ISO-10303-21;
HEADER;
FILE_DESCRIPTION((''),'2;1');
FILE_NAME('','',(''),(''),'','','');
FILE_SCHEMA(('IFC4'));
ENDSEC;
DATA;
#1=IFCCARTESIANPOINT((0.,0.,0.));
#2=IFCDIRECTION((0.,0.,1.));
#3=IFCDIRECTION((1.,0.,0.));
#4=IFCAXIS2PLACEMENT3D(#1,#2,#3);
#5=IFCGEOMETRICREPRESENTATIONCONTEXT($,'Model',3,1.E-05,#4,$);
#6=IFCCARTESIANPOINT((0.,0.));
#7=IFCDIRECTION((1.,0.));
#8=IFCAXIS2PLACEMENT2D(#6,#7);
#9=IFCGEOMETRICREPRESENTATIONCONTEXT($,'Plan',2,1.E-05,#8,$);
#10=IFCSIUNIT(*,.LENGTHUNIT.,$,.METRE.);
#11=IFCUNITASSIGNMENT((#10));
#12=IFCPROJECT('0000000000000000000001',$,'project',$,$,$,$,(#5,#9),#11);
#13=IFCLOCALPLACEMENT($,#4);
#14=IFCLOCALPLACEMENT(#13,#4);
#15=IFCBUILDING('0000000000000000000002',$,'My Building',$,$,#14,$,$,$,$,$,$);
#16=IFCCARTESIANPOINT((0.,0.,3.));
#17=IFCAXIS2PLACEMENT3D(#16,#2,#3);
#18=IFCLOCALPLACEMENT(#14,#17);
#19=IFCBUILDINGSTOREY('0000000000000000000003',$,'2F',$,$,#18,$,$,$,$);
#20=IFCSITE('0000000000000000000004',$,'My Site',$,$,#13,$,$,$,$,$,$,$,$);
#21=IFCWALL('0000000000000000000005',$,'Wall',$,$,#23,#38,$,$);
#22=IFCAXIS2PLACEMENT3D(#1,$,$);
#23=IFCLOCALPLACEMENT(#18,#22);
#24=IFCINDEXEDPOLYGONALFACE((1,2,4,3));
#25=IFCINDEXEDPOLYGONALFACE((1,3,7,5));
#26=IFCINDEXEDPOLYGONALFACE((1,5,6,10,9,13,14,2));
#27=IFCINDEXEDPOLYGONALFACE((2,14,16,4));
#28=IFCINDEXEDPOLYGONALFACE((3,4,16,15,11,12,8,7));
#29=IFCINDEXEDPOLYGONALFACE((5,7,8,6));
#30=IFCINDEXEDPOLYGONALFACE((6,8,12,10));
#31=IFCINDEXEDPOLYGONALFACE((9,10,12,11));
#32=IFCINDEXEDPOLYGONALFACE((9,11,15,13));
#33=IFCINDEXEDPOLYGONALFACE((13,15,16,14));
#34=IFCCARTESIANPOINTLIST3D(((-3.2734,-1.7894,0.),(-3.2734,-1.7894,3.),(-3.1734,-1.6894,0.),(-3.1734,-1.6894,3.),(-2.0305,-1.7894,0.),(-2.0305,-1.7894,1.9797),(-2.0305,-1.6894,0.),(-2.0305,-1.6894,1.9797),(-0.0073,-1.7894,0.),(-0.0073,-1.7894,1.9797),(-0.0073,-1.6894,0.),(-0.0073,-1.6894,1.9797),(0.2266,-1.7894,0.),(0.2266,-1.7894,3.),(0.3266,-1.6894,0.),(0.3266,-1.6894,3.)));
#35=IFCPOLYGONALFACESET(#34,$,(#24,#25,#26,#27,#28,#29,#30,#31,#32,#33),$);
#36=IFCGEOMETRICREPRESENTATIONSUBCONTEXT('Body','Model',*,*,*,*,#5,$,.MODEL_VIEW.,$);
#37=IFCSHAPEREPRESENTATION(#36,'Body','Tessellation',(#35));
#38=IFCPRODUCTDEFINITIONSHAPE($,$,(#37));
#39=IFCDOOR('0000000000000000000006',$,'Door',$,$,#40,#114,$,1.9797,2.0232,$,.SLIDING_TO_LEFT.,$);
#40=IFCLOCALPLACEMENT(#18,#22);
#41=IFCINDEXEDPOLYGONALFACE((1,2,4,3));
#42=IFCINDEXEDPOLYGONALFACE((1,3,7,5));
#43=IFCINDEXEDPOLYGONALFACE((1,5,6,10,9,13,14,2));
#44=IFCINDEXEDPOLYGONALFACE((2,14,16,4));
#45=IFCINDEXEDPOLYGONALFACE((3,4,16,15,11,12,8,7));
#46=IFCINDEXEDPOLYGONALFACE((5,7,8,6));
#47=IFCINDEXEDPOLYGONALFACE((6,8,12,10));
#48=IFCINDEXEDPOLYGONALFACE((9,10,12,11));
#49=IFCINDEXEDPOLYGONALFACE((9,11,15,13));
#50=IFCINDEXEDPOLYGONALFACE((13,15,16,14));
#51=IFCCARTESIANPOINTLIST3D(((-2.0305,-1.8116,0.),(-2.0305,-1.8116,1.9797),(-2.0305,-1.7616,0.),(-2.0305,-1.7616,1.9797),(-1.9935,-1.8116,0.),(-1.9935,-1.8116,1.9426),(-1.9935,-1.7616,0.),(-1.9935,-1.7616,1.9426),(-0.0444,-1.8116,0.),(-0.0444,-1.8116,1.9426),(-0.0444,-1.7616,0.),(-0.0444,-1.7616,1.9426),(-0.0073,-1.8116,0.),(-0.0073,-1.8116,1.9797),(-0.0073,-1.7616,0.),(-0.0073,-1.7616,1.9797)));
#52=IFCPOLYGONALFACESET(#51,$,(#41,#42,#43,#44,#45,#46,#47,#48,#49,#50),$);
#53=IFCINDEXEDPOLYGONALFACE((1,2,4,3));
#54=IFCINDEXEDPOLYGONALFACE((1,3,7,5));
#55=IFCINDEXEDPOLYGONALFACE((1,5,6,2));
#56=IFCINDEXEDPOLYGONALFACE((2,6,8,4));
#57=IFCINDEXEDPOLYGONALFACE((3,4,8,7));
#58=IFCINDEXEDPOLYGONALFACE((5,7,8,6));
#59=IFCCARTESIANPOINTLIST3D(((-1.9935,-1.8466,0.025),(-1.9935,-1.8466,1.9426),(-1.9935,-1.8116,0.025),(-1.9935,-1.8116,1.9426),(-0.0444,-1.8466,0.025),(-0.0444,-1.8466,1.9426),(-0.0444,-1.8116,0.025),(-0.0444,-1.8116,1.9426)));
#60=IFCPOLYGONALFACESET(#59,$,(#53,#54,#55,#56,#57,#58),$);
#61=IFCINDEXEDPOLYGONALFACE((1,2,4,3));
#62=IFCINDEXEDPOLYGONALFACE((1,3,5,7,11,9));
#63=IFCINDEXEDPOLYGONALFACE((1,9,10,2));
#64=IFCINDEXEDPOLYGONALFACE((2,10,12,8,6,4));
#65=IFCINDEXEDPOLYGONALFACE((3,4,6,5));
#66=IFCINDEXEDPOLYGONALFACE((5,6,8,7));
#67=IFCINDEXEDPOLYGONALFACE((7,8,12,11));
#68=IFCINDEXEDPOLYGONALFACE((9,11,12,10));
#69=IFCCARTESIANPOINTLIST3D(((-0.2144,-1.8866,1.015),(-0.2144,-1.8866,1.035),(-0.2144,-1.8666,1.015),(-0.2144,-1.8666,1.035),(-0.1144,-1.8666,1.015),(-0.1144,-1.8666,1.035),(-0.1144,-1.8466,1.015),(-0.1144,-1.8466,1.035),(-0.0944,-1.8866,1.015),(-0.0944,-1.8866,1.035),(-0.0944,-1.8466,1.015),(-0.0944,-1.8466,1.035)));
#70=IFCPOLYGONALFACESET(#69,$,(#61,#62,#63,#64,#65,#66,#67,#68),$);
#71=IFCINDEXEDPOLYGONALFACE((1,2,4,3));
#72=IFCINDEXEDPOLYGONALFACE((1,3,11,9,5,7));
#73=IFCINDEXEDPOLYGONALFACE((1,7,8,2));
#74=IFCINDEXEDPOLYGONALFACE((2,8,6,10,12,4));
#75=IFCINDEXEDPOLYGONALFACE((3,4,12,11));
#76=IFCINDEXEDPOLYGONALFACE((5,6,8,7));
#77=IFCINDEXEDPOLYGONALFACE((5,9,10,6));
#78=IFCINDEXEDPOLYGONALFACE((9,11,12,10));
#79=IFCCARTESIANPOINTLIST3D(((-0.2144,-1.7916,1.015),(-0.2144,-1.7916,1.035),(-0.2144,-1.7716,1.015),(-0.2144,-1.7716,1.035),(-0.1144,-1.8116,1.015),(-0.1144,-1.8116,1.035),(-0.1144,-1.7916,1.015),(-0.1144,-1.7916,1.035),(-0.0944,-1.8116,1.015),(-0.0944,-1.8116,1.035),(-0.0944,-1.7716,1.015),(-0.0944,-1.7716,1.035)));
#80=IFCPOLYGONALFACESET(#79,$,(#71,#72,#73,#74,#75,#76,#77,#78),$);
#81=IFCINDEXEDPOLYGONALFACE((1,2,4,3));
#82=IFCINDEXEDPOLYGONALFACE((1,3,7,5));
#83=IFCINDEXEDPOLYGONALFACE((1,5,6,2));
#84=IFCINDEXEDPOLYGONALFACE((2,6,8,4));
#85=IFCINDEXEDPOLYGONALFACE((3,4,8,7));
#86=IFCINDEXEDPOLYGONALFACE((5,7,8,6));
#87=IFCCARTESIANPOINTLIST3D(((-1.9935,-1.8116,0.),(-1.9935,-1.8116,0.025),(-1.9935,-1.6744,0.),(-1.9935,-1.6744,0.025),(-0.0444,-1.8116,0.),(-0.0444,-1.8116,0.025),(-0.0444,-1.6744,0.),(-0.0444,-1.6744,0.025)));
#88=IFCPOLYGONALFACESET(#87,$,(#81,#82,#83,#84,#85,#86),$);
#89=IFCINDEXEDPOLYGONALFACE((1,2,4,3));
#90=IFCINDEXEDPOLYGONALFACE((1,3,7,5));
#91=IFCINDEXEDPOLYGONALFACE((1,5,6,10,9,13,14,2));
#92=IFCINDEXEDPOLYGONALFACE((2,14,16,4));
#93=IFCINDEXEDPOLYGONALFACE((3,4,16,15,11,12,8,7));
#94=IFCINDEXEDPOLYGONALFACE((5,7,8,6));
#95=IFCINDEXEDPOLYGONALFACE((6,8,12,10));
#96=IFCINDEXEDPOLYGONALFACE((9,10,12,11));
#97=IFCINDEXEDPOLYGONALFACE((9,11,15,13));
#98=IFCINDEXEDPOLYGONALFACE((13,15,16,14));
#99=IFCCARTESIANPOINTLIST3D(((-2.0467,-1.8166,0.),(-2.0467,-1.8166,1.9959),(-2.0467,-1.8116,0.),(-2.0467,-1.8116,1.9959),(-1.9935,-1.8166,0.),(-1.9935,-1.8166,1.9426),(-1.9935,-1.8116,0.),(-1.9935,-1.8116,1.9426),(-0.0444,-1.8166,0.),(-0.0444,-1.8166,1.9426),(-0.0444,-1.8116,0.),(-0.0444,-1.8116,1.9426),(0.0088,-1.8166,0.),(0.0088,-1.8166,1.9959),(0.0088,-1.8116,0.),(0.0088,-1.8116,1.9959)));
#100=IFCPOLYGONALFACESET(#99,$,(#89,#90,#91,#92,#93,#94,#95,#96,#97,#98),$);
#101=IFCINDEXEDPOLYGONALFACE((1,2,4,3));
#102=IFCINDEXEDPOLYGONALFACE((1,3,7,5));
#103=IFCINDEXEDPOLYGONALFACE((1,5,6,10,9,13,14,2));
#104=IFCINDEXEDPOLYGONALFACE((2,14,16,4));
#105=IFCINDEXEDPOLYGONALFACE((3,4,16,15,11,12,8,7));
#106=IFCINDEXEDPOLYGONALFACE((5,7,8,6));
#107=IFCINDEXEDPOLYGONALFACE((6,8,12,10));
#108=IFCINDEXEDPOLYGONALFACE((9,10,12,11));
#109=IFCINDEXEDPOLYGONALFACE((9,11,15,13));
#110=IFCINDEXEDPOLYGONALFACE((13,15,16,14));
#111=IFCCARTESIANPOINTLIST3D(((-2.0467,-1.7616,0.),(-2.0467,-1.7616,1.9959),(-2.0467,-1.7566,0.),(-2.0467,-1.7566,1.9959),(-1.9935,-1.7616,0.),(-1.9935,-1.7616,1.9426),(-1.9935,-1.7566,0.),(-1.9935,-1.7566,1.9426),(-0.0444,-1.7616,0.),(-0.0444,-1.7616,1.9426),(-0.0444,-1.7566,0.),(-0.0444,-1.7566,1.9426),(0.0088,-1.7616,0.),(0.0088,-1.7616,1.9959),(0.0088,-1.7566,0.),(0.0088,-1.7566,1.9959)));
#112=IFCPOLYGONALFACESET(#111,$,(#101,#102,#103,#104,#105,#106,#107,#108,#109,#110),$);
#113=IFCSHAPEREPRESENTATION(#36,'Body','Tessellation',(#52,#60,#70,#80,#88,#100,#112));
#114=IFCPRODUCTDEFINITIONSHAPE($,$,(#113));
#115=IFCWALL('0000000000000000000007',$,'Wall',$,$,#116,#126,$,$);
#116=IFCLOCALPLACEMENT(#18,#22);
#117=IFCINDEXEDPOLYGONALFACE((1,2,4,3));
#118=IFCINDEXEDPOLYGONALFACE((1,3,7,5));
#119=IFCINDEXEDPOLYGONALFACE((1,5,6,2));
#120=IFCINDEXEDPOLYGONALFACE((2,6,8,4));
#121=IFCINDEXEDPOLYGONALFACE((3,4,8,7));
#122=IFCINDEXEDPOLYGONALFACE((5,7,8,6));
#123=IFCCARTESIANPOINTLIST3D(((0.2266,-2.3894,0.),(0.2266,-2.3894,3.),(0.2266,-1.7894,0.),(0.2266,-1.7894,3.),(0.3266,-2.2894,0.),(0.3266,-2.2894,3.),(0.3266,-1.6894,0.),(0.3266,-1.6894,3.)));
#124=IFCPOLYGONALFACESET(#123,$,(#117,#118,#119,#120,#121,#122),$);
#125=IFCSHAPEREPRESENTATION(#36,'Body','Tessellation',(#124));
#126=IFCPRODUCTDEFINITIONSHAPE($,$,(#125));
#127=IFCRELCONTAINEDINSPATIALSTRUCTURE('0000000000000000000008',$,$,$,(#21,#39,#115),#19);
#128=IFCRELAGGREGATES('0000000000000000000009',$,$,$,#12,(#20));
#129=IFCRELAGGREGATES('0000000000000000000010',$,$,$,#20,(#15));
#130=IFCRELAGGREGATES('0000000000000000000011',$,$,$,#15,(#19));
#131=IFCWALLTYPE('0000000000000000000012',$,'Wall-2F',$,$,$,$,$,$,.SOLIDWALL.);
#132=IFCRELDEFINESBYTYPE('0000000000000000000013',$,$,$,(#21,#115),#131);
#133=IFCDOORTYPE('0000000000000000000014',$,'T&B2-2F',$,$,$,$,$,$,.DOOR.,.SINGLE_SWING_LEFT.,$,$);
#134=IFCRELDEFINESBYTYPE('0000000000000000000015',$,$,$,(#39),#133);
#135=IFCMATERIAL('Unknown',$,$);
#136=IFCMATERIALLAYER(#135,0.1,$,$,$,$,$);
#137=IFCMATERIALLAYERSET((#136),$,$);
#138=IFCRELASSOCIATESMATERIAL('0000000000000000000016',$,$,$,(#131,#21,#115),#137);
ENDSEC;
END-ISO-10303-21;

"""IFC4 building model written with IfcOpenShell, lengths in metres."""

from ifc_helpers import new_model, entity, si_unit, frame, origin_with_axes, origin_2d_with_axis, place, context, subcontext, project, spatial, line, indexed_curve, outline, extrude, shape, source, transform, mapped, material, layer, layer_set, layer_usage, type_object, type_shapes, element, fill, save


model = new_model("IFC4")

# Units and contexts
model_context = context("Model", 3, precision=1e-05, world=origin_with_axes())
plan_context = context("Plan", 2, precision=1e-05, world=origin_2d_with_axis())
body_context_1 = subcontext(model_context, "Body", "Model", "MODEL_VIEW")
body_context_2 = subcontext(plan_context, "Body", "Plan", "PLAN_VIEW")
ifc_project = project(units=[si_unit("LENGTHUNIT", "METRE")], contexts=[model_context, plan_context])

# Site, building, storey
site_placement = place(None, origin_with_axes())
site = spatial("IfcSite", under=ifc_project, at=site_placement, Name="My Site")
building_placement = place(site_placement, origin_with_axes())
building = spatial("IfcBuilding", under=site, at=building_placement, Name="My Building")
storey_placement = place(building_placement, frame((0.0, 0.0, 3.0), z_axis=(0.0, 0.0, 1.0), x_axis=(1.0, 0.0, 0.0)))
storey = spatial("IfcBuildingStorey", under=building, at=storey_placement, Name="2F")

# Shared definitions
ifc_material = material(Name="Unknown")

# Shared definitions
ifc_layer_1 = layer(ifc_material, 0.1)
ifc_layer_set_1 = layer_set([ifc_layer_1])
wall_type = type_object("IfcWallType", Name="Wall-2F", PredefinedType="SOLIDWALL", material=ifc_layer_set_1)

# Wall, opening, door
ifc_layer_usage_1 = layer_usage(ifc_layer_set_1, "AXIS2", "POSITIVE", 0.0)
wall_1_placement = place(storey_placement, frame((-3.2734, -1.7894, 0.0), z_axis=(0.0, 0.0, 1.0), x_axis=(1.0, 0.0, 0.0)))
wall_1 = element("IfcWall", 1, at=wall_1_placement, inside=storey, type_object=wall_type, material=ifc_layer_usage_1, Name="Wall", context=body_context_1, shape_type="SweptSolid", body=[
    extrude(outline(indexed_curve([(0.0, 0.0), (0.1, 0.1), (3.6, 0.1), (3.5, 0.0)], segments=[line(1, 2, 3, 4, 1)])), origin_with_axes(), (0.0, 0.0, 1.0), 3.0),
])
shared_shape_1 = source(origin_with_axes(), body_context_1, "Body", "SweptSolid", [
    extrude(outline(indexed_curve([(0.0, 0.0), (2.0232, 0.0), (2.0232, 1.9797), (0.0, 1.9797)], segments=[line(1, 2, 3, 4, 1)])), frame((0.0, -0.6, 0.0), z_axis=(0.0, -1.0, 0.0), x_axis=(1.0, 0.0, 0.0)), (0.0, 0.0, -1.0), 1.2),
])
opening_1_placement = place(wall_1_placement, frame((1.2428, -0.0222, 0.0), z_axis=(0.0, 0.0, 1.0), x_axis=(1.0, 0.0, 0.0)))
opening_1 = element("IfcOpeningElement", 2, at=opening_1_placement, cuts=wall_1, PredefinedType="OPENING", context=body_context_1, shape_type="MappedRepresentation", body=[
    mapped(shared_shape_1, transform((0.0, 0.0, 0.0), x_axis=(1.0, 0.0, 0.0), y_axis=(0.0, 1.0, 0.0), z_axis=(0.0, 0.0, 1.0), scale=1.0)),
])
door_type_1 = type_object("IfcDoorType", Name="T&B2-2F", OperationType="SINGLE_SWING_LEFT", PredefinedType="DOOR")
shared_shape_2 = source(origin_with_axes(), body_context_1, "Body", "SweptSolid", [
    extrude(outline(indexed_curve([(0.0, 0.0), (0.0, 1.9797), (2.0232, 1.9797), (2.0232, 0.0), (1.9861, 0.0), (1.9861, 1.9426), (0.0371, 1.9426), (0.0371, 0.0)], segments=[line(1, 2, 3, 4, 5, 6, 7, 8, 1)])), frame((0.0, 0.0, 0.0), z_axis=(0.0, -1.0, 0.0), x_axis=(1.0, 0.0, 0.0)), (0.0, 0.0, -1.0), 0.05),
    extrude(outline(indexed_curve([(0.0, 0.0), (1.9491, 0.0), (1.9491, 0.035), (0.0, 0.035)], segments=[line(1, 2, 3, 4, 1)])), frame((0.0371, -0.035, 0.025), z_axis=(0.0, 0.0, 1.0), x_axis=(1.0, 0.0, 0.0)), (0.0, 0.0, 1.0), 1.9176),
    extrude(outline(indexed_curve([(0.0, 0.0), (0.0, -0.04), (-0.12, -0.04), (-0.12, -0.02), (-0.02, -0.02), (-0.02, 0.0)], segments=[line(1, 2, 3, 4, 5, 6, 1)])), frame((1.9361, -0.035, 1.015), z_axis=(0.0, 0.0, 1.0), x_axis=(1.0, 0.0, 0.0)), (0.0, 0.0, 1.0), 0.02),
    extrude(outline(indexed_curve([(0.0, 0.0), (0.0, 0.04), (-0.12, 0.04), (-0.12, 0.02), (-0.02, 0.02), (-0.02, 0.0)], segments=[line(1, 2, 3, 4, 5, 6, 1)])), frame((1.9361, 0.0, 1.015), z_axis=(0.0, 0.0, 1.0), x_axis=(1.0, 0.0, 0.0)), (0.0, 0.0, 1.0), 0.02),
    extrude(outline(indexed_curve([(0.0, 0.0), (1.9491, 0.0), (1.9491, 0.1372), (0.0, 0.1372)], segments=[line(1, 2, 3, 4, 1)])), frame((0.0371, 0.0, 0.0), z_axis=(0.0, 0.0, 1.0), x_axis=(1.0, 0.0, 0.0)), (0.0, 0.0, 1.0), 0.025),
    extrude(outline(indexed_curve([(0.0, 0.0), (0.0, 1.9959), (2.0555, 1.9959), (2.0555, 0.0), (2.0023, 0.0), (2.0023, 1.9426), (0.0532, 1.9426), (0.0532, 0.0)], segments=[line(1, 2, 3, 4, 5, 6, 7, 8, 1)])), frame((-0.0162, -0.005, 0.0), z_axis=(0.0, -1.0, 0.0), x_axis=(1.0, 0.0, 0.0)), (0.0, 0.0, -1.0), 0.005),
    extrude(outline(indexed_curve([(0.0, 0.0), (0.0, 1.9959), (2.0555, 1.9959), (2.0555, 0.0), (2.0023, 0.0), (2.0023, 1.9426), (0.0532, 1.9426), (0.0532, 0.0)], segments=[line(1, 2, 3, 4, 5, 6, 7, 8, 1)])), frame((-0.0162, 0.05, 0.0), z_axis=(0.0, -1.0, 0.0), x_axis=(1.0, 0.0, 0.0)), (0.0, 0.0, -1.0), 0.005),
])
shared_shape_3 = source(origin_with_axes(), body_context_2, "Body", "Curve2D", [
    entity("IfcIndexedPolyCurve", entity("IfcCartesianPointList2D", [[0.0, 0.0], [0.0371, 0.0], [0.0371, 0.05], [0.0, 0.05]]), [entity("IfcLineIndex", [1, 2, 3, 4, 1])]),
    entity("IfcIndexedPolyCurve", entity("IfcCartesianPointList2D", [[2.0232, 0.0], [1.9861, 0.0], [1.9861, 0.05], [2.0232, 0.05]]), [entity("IfcLineIndex", [1, 2, 3, 4, 1])]),
    entity("IfcIndexedPolyCurve", entity("IfcCartesianPointList2D", [[-0.9374, -0.035], [1.0116, -0.035], [1.0116, 0.0], [-0.9374, 0.0]]), [entity("IfcLineIndex", [1, 2, 3, 4, 1])]),
])
type_shapes(door_type_1, [shared_shape_2, shared_shape_3])
door_1_placement = place(opening_1_placement, origin_with_axes())
door_1 = element("IfcDoor", 3, at=door_1_placement, inside=storey, type_object=door_type_1, Name="Door", OperationType="SLIDING_TO_LEFT", OverallHeight=1.9797, OverallWidth=2.0232, shapes=[
    shape(body_context_1, "Body", "MappedRepresentation", [mapped(shared_shape_2, transform((0.0, 0.0, 0.0), x_axis=(1.0, 0.0, 0.0), y_axis=(0.0, 1.0, 0.0), z_axis=(0.0, 0.0, 1.0), scale=1.0))]),
    shape(body_context_2, "Body", "MappedRepresentation", [mapped(shared_shape_3, transform((0.0, 0.0, 0.0), x_axis=(1.0, 0.0, 0.0), y_axis=(0.0, 1.0, 0.0), z_axis=(0.0, 0.0, 1.0), scale=1.0))]),
])
fill(opening_1, door_1)

# Wall
ifc_layer_usage_2 = layer_usage(ifc_layer_set_1, "AXIS2", "POSITIVE", 0.0)
wall_2_placement = place(storey_placement, frame((0.2266, -1.7894, 0.0), z_axis=(0.0, 0.0, 1.0), x_axis=(0.0, -1.0, 0.0)))
element("IfcWall", 4, at=wall_2_placement, inside=storey, type_object=wall_type, material=ifc_layer_usage_2, Name="Wall", context=body_context_1, shape_type="SweptSolid", body=[
    extrude(outline(indexed_curve([(0.0, 0.0), (-0.1, 0.1), (0.5, 0.1), (0.6, 0.0)], segments=[line(1, 2, 3, 4, 1)])), origin_with_axes(), (0.0, 0.0, 1.0), 3.0),
])

save(model, "model.ifc")
